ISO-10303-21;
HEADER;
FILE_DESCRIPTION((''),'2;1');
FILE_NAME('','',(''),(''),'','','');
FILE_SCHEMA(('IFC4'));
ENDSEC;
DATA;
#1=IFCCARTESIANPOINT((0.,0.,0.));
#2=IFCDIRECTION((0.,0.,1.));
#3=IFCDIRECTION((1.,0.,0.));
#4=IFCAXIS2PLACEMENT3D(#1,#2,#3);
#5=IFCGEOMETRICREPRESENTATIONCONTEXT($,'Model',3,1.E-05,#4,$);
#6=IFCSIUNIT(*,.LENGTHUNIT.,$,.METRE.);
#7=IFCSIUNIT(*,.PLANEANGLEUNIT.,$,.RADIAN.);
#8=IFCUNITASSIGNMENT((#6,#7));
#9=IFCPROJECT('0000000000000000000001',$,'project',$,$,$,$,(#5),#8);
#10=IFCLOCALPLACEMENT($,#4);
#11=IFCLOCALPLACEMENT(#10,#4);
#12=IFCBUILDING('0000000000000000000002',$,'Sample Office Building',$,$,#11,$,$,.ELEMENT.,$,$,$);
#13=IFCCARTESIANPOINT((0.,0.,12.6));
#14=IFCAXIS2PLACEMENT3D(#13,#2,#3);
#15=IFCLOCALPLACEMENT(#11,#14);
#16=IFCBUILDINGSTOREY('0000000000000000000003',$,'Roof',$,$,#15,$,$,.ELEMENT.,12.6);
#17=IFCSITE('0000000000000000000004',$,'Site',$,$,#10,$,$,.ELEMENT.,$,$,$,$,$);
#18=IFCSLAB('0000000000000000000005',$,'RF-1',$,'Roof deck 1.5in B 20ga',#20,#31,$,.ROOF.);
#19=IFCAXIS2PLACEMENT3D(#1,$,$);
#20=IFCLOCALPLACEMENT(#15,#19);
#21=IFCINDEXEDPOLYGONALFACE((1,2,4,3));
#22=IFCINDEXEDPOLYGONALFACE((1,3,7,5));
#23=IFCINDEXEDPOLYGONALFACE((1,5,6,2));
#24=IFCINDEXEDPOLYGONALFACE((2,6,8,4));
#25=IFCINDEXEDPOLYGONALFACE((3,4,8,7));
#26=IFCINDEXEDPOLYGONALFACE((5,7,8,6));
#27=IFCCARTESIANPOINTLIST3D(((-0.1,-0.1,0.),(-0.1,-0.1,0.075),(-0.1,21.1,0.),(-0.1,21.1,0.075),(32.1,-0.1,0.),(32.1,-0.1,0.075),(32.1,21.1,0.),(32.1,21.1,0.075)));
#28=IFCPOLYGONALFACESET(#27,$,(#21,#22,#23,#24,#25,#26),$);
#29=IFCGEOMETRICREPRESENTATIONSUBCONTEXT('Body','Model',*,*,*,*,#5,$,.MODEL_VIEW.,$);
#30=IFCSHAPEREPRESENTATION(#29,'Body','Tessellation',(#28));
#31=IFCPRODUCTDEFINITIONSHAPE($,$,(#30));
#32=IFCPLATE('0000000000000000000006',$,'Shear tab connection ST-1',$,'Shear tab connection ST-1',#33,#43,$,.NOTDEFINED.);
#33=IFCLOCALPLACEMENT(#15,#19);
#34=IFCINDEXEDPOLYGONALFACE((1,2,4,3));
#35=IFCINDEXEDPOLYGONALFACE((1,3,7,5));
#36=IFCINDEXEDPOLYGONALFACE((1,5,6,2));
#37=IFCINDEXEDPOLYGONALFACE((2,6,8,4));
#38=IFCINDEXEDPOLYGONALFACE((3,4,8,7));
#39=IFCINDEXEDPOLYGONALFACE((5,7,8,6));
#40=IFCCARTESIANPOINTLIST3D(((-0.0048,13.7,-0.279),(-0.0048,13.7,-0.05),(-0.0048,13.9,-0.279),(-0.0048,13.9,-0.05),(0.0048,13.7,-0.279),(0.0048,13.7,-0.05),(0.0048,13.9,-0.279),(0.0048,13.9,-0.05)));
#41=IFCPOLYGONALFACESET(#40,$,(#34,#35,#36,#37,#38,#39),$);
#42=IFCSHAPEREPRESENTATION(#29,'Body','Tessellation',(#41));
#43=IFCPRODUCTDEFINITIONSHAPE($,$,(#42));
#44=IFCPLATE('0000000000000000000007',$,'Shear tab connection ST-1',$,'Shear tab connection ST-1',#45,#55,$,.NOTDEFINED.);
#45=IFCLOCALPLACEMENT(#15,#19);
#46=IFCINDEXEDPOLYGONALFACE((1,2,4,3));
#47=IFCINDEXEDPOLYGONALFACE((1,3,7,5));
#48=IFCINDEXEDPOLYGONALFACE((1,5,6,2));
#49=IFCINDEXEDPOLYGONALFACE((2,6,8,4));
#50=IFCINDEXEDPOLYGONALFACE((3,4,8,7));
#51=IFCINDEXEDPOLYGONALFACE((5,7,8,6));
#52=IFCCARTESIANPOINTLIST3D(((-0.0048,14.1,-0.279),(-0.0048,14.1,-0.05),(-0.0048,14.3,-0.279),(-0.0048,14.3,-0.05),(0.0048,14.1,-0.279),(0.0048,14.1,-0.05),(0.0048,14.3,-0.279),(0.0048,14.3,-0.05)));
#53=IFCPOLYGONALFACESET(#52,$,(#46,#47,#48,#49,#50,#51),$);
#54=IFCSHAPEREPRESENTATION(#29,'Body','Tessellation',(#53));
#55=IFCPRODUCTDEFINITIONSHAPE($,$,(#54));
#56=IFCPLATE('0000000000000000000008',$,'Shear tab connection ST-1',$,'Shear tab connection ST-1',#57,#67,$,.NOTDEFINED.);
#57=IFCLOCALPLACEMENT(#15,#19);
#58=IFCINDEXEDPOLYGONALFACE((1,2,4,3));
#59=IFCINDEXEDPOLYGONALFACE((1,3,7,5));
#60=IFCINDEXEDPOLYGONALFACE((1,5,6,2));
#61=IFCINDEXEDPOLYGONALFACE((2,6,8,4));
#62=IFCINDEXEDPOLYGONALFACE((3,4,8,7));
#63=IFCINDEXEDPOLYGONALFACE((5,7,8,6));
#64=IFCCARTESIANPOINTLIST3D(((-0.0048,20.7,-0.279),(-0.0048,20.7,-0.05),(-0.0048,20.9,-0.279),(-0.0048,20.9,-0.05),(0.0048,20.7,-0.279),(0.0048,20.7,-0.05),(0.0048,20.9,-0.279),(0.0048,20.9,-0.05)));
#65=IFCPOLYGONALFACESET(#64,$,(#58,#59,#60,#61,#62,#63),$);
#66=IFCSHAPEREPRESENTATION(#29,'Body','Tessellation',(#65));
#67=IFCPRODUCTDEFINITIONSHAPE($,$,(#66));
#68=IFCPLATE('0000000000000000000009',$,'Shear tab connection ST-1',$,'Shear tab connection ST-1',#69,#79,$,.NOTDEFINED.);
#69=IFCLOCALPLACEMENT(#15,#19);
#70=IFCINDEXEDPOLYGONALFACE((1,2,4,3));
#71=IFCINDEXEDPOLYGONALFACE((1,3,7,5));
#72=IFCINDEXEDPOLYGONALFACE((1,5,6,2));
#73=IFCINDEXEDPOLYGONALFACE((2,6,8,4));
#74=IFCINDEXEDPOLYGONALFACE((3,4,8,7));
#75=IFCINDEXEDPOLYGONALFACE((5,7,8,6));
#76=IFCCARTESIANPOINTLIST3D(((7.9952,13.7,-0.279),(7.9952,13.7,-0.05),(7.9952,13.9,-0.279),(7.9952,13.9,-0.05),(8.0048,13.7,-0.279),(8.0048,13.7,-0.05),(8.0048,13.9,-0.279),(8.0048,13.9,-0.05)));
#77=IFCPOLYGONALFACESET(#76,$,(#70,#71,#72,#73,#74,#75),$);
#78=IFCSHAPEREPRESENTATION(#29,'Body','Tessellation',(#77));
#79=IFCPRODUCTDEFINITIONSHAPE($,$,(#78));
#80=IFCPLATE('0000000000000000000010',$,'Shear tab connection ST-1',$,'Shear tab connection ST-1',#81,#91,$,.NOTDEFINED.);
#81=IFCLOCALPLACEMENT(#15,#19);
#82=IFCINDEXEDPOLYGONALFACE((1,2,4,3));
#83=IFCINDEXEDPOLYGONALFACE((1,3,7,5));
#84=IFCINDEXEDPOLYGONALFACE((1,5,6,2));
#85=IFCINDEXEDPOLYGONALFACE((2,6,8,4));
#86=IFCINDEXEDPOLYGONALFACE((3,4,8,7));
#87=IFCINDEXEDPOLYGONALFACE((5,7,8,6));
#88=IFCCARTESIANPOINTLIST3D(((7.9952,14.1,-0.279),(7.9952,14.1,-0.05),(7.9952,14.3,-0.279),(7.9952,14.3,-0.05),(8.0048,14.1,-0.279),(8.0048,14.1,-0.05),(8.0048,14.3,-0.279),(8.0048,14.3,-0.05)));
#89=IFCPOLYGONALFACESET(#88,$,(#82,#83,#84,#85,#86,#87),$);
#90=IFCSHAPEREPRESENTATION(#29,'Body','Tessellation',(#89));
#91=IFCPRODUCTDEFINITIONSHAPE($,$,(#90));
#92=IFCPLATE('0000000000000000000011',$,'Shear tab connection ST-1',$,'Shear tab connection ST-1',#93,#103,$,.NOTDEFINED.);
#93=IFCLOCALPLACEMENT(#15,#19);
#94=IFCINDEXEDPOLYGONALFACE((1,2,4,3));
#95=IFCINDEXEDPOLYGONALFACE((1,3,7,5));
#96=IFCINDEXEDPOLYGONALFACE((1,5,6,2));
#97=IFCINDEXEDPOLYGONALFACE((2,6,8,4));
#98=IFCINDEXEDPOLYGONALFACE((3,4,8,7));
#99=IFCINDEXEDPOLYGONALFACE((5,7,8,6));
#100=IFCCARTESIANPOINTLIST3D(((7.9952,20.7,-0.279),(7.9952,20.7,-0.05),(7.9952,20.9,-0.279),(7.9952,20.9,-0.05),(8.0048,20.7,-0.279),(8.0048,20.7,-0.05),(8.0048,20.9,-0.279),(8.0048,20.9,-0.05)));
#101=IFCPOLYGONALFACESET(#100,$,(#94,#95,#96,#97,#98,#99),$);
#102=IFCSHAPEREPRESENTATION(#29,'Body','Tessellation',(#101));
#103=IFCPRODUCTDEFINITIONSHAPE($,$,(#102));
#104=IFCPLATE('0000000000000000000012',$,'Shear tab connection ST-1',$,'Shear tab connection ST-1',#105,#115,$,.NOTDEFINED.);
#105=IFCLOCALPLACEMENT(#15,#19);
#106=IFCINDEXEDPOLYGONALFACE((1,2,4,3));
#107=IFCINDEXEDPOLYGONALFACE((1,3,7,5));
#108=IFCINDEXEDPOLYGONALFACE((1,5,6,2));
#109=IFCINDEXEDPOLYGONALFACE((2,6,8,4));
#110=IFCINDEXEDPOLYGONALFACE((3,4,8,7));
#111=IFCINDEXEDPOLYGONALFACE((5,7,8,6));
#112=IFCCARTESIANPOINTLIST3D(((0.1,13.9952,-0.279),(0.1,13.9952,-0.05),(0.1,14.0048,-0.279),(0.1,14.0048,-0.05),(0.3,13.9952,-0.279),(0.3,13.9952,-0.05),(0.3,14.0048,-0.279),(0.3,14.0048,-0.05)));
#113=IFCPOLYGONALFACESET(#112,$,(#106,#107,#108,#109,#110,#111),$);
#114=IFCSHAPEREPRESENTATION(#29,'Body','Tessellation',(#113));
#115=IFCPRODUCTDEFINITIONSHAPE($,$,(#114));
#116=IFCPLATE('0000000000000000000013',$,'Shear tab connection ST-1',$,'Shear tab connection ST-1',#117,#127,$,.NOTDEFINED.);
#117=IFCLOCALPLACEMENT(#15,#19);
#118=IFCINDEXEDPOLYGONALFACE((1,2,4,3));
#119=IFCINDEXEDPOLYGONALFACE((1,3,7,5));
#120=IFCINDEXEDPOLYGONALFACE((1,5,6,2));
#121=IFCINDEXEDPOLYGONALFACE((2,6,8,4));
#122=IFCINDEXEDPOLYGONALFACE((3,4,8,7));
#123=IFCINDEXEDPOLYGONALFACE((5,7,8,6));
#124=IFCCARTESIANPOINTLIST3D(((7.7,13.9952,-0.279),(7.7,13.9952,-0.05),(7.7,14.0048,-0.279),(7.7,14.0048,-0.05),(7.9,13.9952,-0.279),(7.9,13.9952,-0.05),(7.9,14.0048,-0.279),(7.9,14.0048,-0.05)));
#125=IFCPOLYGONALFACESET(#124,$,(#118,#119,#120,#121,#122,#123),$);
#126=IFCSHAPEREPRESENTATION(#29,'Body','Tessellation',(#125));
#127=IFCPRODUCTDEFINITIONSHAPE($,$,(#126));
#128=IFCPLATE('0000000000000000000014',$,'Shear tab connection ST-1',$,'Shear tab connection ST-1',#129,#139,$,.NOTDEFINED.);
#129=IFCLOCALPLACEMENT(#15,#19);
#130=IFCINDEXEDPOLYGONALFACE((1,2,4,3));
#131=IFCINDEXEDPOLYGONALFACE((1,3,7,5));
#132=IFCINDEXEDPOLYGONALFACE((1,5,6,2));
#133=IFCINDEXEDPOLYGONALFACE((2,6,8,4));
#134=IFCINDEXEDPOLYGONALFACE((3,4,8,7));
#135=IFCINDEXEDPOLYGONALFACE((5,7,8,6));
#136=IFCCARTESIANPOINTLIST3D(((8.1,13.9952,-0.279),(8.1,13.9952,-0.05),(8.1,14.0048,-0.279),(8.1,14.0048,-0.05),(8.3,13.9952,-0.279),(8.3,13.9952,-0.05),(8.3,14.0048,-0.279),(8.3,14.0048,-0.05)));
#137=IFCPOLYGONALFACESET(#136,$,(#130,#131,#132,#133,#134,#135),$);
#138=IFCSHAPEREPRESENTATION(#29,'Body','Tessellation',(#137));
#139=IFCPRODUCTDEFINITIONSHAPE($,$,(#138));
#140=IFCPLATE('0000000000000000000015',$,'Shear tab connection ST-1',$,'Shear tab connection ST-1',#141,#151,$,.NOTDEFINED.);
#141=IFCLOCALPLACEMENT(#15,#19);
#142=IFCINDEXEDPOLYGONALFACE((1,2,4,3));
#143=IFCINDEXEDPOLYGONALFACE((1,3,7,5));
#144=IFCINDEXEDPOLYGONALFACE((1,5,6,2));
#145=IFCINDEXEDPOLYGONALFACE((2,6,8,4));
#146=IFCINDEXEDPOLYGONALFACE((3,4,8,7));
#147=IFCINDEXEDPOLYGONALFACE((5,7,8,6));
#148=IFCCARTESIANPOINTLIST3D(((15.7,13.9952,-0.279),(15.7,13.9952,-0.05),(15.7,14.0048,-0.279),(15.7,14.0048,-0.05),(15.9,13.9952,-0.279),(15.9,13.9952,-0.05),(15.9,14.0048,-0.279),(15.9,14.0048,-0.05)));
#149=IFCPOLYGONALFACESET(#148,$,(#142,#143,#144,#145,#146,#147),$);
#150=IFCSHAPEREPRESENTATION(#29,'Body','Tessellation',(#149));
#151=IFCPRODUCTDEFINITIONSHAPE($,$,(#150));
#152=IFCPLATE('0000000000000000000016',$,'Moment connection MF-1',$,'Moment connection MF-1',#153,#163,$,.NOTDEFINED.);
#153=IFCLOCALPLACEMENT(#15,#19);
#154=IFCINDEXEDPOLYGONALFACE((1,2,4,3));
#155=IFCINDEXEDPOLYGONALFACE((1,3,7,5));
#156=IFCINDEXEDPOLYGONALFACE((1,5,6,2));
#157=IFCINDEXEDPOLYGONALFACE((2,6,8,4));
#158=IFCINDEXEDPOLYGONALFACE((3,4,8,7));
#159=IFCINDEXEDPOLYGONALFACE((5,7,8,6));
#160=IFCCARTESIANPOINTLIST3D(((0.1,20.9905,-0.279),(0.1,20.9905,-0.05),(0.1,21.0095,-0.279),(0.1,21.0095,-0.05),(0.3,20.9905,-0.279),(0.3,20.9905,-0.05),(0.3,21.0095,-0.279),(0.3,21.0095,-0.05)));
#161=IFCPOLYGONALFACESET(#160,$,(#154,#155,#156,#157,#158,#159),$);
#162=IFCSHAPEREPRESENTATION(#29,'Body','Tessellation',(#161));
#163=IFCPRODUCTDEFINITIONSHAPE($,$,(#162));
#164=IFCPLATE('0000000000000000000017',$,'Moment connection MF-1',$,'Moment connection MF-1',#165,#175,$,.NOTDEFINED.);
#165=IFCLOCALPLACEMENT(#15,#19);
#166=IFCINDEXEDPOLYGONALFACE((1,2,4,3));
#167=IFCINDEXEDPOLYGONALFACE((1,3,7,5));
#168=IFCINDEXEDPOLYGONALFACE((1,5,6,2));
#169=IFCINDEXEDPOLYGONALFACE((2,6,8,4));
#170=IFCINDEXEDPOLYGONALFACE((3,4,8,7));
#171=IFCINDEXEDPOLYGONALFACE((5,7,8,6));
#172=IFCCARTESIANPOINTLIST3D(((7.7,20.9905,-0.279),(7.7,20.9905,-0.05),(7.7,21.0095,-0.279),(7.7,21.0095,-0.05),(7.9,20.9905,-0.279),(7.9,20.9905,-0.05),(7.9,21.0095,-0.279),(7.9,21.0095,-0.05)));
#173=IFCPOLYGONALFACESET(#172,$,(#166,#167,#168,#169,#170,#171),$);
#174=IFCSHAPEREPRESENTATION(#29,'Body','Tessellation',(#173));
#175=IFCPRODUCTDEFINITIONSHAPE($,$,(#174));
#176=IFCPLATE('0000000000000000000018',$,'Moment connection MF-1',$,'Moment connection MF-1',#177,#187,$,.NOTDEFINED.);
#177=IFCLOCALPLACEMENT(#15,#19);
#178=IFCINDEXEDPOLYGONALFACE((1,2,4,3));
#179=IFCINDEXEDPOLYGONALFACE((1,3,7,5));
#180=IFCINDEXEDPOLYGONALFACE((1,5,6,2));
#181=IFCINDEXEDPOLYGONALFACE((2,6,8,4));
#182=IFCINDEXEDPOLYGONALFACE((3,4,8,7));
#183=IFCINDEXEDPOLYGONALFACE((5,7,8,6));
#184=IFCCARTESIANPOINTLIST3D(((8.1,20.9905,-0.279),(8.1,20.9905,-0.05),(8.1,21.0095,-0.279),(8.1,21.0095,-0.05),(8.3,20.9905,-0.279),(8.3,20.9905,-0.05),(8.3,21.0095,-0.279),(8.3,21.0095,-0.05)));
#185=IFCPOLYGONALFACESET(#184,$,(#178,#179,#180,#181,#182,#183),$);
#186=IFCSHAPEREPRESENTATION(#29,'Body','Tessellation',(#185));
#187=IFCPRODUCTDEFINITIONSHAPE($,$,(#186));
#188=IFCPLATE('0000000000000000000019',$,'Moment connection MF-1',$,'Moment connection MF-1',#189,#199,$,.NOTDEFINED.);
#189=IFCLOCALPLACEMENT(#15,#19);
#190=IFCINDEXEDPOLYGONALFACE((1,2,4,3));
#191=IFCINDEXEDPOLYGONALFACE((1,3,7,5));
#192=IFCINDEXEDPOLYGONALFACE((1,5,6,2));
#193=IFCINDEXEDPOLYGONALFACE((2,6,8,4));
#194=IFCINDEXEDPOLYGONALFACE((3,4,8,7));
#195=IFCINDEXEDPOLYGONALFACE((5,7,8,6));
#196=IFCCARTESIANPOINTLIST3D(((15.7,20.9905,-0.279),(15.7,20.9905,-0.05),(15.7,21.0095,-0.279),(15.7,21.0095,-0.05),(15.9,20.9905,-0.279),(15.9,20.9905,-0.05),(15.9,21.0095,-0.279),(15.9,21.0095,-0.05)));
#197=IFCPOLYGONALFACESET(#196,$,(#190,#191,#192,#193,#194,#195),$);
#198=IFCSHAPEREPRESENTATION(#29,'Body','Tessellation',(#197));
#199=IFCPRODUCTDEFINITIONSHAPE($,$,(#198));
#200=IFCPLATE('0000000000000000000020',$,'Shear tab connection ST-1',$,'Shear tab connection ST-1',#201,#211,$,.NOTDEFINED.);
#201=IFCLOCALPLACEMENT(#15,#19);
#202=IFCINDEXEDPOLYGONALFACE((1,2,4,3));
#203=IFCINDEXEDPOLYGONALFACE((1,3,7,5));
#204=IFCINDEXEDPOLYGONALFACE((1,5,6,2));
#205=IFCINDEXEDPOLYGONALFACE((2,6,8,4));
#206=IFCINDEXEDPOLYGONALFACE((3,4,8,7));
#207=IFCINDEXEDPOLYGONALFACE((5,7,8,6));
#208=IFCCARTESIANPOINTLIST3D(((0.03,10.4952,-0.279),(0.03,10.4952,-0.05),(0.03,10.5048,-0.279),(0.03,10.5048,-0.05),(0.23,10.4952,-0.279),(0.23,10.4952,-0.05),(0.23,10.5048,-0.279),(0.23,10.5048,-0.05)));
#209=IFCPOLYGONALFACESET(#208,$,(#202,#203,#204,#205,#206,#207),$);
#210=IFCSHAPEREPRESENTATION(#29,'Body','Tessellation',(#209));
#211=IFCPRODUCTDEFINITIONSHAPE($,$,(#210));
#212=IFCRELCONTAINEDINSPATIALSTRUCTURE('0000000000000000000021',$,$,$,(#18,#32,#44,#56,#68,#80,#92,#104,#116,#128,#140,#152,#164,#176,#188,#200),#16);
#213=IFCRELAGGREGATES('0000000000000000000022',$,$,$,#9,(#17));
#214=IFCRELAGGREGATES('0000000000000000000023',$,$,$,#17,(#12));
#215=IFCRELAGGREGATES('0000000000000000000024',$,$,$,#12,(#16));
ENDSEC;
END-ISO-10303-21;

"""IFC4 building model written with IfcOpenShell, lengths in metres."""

from ifc_helpers import new_model, si_unit, frame, origin_with_axes, place, context, subcontext, project, spatial, rectangle, extrude, element, save


model = new_model("IFC4")

# Units and contexts
model_context = context("Model", 3, precision=1e-05, world=origin_with_axes())
body_context = subcontext(model_context, "Body", "Model", "MODEL_VIEW")
ifc_project = project(units=[si_unit("LENGTHUNIT", "METRE"), si_unit("PLANEANGLEUNIT", "RADIAN")], contexts=[model_context])

# Site, building, storey
site_placement = place(None, origin_with_axes())
site = spatial("IfcSite", under=ifc_project, at=site_placement, Name="Site", CompositionType="ELEMENT")
building_placement = place(site_placement, origin_with_axes())
building = spatial("IfcBuilding", under=site, at=building_placement, Name="Sample Office Building", CompositionType="ELEMENT")
storey_placement = place(building_placement, frame((0.0, 0.0, 12.6), z_axis=(0.0, 0.0, 1.0), x_axis=(1.0, 0.0, 0.0)))
storey = spatial("IfcBuildingStorey", under=building, at=storey_placement, Name="Roof", CompositionType="ELEMENT", Elevation=12.6)

# Slab
slab_placement = place(None, frame((16.0, 10.5, 12.6), z_axis=(0.0, 0.0, 1.0), x_axis=(1.0, 0.0, 0.0)))
element("IfcSlab", 1, at=slab_placement, inside=storey, Name="RF-1", ObjectType="Roof deck 1.5in B 20ga", PredefinedType="ROOF", context=body_context, shape_type="SweptSolid", body=[
    extrude(rectangle(XDim=32.2, YDim=21.2), None, (0.0, 0.0, 1.0), 0.075),
])

# Plates
for number, where, z_axis, x_axis, name in (
    (2, (0.0, 13.8, 12.321), (0.0, 0.0, 1.0), (1.0, 0.0, 0.0), "Shear tab connection ST-1"),
    (3, (0.0, 14.2, 12.321), (0.0, 0.0, 1.0), (1.0, 0.0, 0.0), "Shear tab connection ST-1"),
):
    element("IfcPlate", number, at=place(None, frame(where, z_axis=z_axis, x_axis=x_axis)), inside=storey, Name=name, ObjectType="Shear tab connection ST-1", PredefinedType="NOTDEFINED", context=body_context, shape_type="SweptSolid", body=[
        extrude(rectangle(XDim=0.0095, YDim=0.2), None, (0.0, 0.0, 1.0), 0.229),
    ])
plate_1_placement = place(None, frame((0.0, 20.8, 12.321), z_axis=(0.0, 0.0, 1.0), x_axis=(1.0, 0.0, 0.0)))
element("IfcPlate", 4, at=plate_1_placement, inside=storey, Name="Shear tab connection ST-1", ObjectType="Shear tab connection ST-1", PredefinedType="NOTDEFINED", context=body_context, shape_type="SweptSolid", body=[
    extrude(rectangle(XDim=0.0095, YDim=0.2), None, (0.0, 0.0, 1.0), 0.229),
])
for number, where, z_axis, x_axis, name in (
    (5, (8.0, 13.8, 12.321), (0.0, 0.0, 1.0), (1.0, 0.0, 0.0), "Shear tab connection ST-1"),
    (6, (8.0, 14.2, 12.321), (0.0, 0.0, 1.0), (1.0, 0.0, 0.0), "Shear tab connection ST-1"),
):
    element("IfcPlate", number, at=place(None, frame(where, z_axis=z_axis, x_axis=x_axis)), inside=storey, Name=name, ObjectType="Shear tab connection ST-1", PredefinedType="NOTDEFINED", context=body_context, shape_type="SweptSolid", body=[
        extrude(rectangle(XDim=0.0095, YDim=0.2), None, (0.0, 0.0, 1.0), 0.229),
    ])
plate_2_placement = place(None, frame((8.0, 20.8, 12.321), z_axis=(0.0, 0.0, 1.0), x_axis=(1.0, 0.0, 0.0)))
element("IfcPlate", 7, at=plate_2_placement, inside=storey, Name="Shear tab connection ST-1", ObjectType="Shear tab connection ST-1", PredefinedType="NOTDEFINED", context=body_context, shape_type="SweptSolid", body=[
    extrude(rectangle(XDim=0.0095, YDim=0.2), None, (0.0, 0.0, 1.0), 0.229),
])
plate_3_placement = place(None, frame((0.2, 14.0, 12.321), z_axis=(0.0, 0.0, 1.0), x_axis=(1.0, 0.0, 0.0)))
element("IfcPlate", 8, at=plate_3_placement, inside=storey, Name="Shear tab connection ST-1", ObjectType="Shear tab connection ST-1", PredefinedType="NOTDEFINED", context=body_context, shape_type="SweptSolid", body=[
    extrude(rectangle(XDim=0.2, YDim=0.0095), None, (0.0, 0.0, 1.0), 0.229),
])
plate_4_placement = place(None, frame((7.8, 14.0, 12.321), z_axis=(0.0, 0.0, 1.0), x_axis=(1.0, 0.0, 0.0)))
element("IfcPlate", 9, at=plate_4_placement, inside=storey, Name="Shear tab connection ST-1", ObjectType="Shear tab connection ST-1", PredefinedType="NOTDEFINED", context=body_context, shape_type="SweptSolid", body=[
    extrude(rectangle(XDim=0.2, YDim=0.0095), None, (0.0, 0.0, 1.0), 0.229),
])
for number, where, z_axis, x_axis, name in (
    (10, (8.2, 14.0, 12.321), (0.0, 0.0, 1.0), (1.0, 0.0, 0.0), "Shear tab connection ST-1"),
    (11, (15.8, 14.0, 12.321), (0.0, 0.0, 1.0), (1.0, 0.0, 0.0), "Shear tab connection ST-1"),
):
    element("IfcPlate", number, at=place(None, frame(where, z_axis=z_axis, x_axis=x_axis)), inside=storey, Name=name, ObjectType="Shear tab connection ST-1", PredefinedType="NOTDEFINED", context=body_context, shape_type="SweptSolid", body=[
        extrude(rectangle(XDim=0.2, YDim=0.0095), None, (0.0, 0.0, 1.0), 0.229),
    ])
plate_5_placement = place(None, frame((0.2, 21.0, 12.321), z_axis=(0.0, 0.0, 1.0), x_axis=(1.0, 0.0, 0.0)))
element("IfcPlate", 12, at=plate_5_placement, inside=storey, Name="Moment connection MF-1", ObjectType="Moment connection MF-1", PredefinedType="NOTDEFINED", context=body_context, shape_type="SweptSolid", body=[
    extrude(rectangle(XDim=0.2, YDim=0.019), None, (0.0, 0.0, 1.0), 0.229),
])
plate_6_placement = place(None, frame((7.8, 21.0, 12.321), z_axis=(0.0, 0.0, 1.0), x_axis=(1.0, 0.0, 0.0)))
element("IfcPlate", 13, at=plate_6_placement, inside=storey, Name="Moment connection MF-1", ObjectType="Moment connection MF-1", PredefinedType="NOTDEFINED", context=body_context, shape_type="SweptSolid", body=[
    extrude(rectangle(XDim=0.2, YDim=0.019), None, (0.0, 0.0, 1.0), 0.229),
])
for number, where, z_axis, x_axis, name in (
    (14, (8.2, 21.0, 12.321), (0.0, 0.0, 1.0), (1.0, 0.0, 0.0), "Moment connection MF-1"),
    (15, (15.8, 21.0, 12.321), (0.0, 0.0, 1.0), (1.0, 0.0, 0.0), "Moment connection MF-1"),
):
    element("IfcPlate", number, at=place(None, frame(where, z_axis=z_axis, x_axis=x_axis)), inside=storey, Name=name, ObjectType="Moment connection MF-1", PredefinedType="NOTDEFINED", context=body_context, shape_type="SweptSolid", body=[
        extrude(rectangle(XDim=0.2, YDim=0.019), None, (0.0, 0.0, 1.0), 0.229),
    ])
plate_7_placement = place(None, frame((0.13, 10.5, 12.321), z_axis=(0.0, 0.0, 1.0), x_axis=(1.0, 0.0, 0.0)))
element("IfcPlate", 16, at=plate_7_placement, inside=storey, Name="Shear tab connection ST-1", ObjectType="Shear tab connection ST-1", PredefinedType="NOTDEFINED", context=body_context, shape_type="SweptSolid", body=[
    extrude(rectangle(XDim=0.2, YDim=0.0095), None, (0.0, 0.0, 1.0), 0.229),
])

save(model, "model.ifc")
